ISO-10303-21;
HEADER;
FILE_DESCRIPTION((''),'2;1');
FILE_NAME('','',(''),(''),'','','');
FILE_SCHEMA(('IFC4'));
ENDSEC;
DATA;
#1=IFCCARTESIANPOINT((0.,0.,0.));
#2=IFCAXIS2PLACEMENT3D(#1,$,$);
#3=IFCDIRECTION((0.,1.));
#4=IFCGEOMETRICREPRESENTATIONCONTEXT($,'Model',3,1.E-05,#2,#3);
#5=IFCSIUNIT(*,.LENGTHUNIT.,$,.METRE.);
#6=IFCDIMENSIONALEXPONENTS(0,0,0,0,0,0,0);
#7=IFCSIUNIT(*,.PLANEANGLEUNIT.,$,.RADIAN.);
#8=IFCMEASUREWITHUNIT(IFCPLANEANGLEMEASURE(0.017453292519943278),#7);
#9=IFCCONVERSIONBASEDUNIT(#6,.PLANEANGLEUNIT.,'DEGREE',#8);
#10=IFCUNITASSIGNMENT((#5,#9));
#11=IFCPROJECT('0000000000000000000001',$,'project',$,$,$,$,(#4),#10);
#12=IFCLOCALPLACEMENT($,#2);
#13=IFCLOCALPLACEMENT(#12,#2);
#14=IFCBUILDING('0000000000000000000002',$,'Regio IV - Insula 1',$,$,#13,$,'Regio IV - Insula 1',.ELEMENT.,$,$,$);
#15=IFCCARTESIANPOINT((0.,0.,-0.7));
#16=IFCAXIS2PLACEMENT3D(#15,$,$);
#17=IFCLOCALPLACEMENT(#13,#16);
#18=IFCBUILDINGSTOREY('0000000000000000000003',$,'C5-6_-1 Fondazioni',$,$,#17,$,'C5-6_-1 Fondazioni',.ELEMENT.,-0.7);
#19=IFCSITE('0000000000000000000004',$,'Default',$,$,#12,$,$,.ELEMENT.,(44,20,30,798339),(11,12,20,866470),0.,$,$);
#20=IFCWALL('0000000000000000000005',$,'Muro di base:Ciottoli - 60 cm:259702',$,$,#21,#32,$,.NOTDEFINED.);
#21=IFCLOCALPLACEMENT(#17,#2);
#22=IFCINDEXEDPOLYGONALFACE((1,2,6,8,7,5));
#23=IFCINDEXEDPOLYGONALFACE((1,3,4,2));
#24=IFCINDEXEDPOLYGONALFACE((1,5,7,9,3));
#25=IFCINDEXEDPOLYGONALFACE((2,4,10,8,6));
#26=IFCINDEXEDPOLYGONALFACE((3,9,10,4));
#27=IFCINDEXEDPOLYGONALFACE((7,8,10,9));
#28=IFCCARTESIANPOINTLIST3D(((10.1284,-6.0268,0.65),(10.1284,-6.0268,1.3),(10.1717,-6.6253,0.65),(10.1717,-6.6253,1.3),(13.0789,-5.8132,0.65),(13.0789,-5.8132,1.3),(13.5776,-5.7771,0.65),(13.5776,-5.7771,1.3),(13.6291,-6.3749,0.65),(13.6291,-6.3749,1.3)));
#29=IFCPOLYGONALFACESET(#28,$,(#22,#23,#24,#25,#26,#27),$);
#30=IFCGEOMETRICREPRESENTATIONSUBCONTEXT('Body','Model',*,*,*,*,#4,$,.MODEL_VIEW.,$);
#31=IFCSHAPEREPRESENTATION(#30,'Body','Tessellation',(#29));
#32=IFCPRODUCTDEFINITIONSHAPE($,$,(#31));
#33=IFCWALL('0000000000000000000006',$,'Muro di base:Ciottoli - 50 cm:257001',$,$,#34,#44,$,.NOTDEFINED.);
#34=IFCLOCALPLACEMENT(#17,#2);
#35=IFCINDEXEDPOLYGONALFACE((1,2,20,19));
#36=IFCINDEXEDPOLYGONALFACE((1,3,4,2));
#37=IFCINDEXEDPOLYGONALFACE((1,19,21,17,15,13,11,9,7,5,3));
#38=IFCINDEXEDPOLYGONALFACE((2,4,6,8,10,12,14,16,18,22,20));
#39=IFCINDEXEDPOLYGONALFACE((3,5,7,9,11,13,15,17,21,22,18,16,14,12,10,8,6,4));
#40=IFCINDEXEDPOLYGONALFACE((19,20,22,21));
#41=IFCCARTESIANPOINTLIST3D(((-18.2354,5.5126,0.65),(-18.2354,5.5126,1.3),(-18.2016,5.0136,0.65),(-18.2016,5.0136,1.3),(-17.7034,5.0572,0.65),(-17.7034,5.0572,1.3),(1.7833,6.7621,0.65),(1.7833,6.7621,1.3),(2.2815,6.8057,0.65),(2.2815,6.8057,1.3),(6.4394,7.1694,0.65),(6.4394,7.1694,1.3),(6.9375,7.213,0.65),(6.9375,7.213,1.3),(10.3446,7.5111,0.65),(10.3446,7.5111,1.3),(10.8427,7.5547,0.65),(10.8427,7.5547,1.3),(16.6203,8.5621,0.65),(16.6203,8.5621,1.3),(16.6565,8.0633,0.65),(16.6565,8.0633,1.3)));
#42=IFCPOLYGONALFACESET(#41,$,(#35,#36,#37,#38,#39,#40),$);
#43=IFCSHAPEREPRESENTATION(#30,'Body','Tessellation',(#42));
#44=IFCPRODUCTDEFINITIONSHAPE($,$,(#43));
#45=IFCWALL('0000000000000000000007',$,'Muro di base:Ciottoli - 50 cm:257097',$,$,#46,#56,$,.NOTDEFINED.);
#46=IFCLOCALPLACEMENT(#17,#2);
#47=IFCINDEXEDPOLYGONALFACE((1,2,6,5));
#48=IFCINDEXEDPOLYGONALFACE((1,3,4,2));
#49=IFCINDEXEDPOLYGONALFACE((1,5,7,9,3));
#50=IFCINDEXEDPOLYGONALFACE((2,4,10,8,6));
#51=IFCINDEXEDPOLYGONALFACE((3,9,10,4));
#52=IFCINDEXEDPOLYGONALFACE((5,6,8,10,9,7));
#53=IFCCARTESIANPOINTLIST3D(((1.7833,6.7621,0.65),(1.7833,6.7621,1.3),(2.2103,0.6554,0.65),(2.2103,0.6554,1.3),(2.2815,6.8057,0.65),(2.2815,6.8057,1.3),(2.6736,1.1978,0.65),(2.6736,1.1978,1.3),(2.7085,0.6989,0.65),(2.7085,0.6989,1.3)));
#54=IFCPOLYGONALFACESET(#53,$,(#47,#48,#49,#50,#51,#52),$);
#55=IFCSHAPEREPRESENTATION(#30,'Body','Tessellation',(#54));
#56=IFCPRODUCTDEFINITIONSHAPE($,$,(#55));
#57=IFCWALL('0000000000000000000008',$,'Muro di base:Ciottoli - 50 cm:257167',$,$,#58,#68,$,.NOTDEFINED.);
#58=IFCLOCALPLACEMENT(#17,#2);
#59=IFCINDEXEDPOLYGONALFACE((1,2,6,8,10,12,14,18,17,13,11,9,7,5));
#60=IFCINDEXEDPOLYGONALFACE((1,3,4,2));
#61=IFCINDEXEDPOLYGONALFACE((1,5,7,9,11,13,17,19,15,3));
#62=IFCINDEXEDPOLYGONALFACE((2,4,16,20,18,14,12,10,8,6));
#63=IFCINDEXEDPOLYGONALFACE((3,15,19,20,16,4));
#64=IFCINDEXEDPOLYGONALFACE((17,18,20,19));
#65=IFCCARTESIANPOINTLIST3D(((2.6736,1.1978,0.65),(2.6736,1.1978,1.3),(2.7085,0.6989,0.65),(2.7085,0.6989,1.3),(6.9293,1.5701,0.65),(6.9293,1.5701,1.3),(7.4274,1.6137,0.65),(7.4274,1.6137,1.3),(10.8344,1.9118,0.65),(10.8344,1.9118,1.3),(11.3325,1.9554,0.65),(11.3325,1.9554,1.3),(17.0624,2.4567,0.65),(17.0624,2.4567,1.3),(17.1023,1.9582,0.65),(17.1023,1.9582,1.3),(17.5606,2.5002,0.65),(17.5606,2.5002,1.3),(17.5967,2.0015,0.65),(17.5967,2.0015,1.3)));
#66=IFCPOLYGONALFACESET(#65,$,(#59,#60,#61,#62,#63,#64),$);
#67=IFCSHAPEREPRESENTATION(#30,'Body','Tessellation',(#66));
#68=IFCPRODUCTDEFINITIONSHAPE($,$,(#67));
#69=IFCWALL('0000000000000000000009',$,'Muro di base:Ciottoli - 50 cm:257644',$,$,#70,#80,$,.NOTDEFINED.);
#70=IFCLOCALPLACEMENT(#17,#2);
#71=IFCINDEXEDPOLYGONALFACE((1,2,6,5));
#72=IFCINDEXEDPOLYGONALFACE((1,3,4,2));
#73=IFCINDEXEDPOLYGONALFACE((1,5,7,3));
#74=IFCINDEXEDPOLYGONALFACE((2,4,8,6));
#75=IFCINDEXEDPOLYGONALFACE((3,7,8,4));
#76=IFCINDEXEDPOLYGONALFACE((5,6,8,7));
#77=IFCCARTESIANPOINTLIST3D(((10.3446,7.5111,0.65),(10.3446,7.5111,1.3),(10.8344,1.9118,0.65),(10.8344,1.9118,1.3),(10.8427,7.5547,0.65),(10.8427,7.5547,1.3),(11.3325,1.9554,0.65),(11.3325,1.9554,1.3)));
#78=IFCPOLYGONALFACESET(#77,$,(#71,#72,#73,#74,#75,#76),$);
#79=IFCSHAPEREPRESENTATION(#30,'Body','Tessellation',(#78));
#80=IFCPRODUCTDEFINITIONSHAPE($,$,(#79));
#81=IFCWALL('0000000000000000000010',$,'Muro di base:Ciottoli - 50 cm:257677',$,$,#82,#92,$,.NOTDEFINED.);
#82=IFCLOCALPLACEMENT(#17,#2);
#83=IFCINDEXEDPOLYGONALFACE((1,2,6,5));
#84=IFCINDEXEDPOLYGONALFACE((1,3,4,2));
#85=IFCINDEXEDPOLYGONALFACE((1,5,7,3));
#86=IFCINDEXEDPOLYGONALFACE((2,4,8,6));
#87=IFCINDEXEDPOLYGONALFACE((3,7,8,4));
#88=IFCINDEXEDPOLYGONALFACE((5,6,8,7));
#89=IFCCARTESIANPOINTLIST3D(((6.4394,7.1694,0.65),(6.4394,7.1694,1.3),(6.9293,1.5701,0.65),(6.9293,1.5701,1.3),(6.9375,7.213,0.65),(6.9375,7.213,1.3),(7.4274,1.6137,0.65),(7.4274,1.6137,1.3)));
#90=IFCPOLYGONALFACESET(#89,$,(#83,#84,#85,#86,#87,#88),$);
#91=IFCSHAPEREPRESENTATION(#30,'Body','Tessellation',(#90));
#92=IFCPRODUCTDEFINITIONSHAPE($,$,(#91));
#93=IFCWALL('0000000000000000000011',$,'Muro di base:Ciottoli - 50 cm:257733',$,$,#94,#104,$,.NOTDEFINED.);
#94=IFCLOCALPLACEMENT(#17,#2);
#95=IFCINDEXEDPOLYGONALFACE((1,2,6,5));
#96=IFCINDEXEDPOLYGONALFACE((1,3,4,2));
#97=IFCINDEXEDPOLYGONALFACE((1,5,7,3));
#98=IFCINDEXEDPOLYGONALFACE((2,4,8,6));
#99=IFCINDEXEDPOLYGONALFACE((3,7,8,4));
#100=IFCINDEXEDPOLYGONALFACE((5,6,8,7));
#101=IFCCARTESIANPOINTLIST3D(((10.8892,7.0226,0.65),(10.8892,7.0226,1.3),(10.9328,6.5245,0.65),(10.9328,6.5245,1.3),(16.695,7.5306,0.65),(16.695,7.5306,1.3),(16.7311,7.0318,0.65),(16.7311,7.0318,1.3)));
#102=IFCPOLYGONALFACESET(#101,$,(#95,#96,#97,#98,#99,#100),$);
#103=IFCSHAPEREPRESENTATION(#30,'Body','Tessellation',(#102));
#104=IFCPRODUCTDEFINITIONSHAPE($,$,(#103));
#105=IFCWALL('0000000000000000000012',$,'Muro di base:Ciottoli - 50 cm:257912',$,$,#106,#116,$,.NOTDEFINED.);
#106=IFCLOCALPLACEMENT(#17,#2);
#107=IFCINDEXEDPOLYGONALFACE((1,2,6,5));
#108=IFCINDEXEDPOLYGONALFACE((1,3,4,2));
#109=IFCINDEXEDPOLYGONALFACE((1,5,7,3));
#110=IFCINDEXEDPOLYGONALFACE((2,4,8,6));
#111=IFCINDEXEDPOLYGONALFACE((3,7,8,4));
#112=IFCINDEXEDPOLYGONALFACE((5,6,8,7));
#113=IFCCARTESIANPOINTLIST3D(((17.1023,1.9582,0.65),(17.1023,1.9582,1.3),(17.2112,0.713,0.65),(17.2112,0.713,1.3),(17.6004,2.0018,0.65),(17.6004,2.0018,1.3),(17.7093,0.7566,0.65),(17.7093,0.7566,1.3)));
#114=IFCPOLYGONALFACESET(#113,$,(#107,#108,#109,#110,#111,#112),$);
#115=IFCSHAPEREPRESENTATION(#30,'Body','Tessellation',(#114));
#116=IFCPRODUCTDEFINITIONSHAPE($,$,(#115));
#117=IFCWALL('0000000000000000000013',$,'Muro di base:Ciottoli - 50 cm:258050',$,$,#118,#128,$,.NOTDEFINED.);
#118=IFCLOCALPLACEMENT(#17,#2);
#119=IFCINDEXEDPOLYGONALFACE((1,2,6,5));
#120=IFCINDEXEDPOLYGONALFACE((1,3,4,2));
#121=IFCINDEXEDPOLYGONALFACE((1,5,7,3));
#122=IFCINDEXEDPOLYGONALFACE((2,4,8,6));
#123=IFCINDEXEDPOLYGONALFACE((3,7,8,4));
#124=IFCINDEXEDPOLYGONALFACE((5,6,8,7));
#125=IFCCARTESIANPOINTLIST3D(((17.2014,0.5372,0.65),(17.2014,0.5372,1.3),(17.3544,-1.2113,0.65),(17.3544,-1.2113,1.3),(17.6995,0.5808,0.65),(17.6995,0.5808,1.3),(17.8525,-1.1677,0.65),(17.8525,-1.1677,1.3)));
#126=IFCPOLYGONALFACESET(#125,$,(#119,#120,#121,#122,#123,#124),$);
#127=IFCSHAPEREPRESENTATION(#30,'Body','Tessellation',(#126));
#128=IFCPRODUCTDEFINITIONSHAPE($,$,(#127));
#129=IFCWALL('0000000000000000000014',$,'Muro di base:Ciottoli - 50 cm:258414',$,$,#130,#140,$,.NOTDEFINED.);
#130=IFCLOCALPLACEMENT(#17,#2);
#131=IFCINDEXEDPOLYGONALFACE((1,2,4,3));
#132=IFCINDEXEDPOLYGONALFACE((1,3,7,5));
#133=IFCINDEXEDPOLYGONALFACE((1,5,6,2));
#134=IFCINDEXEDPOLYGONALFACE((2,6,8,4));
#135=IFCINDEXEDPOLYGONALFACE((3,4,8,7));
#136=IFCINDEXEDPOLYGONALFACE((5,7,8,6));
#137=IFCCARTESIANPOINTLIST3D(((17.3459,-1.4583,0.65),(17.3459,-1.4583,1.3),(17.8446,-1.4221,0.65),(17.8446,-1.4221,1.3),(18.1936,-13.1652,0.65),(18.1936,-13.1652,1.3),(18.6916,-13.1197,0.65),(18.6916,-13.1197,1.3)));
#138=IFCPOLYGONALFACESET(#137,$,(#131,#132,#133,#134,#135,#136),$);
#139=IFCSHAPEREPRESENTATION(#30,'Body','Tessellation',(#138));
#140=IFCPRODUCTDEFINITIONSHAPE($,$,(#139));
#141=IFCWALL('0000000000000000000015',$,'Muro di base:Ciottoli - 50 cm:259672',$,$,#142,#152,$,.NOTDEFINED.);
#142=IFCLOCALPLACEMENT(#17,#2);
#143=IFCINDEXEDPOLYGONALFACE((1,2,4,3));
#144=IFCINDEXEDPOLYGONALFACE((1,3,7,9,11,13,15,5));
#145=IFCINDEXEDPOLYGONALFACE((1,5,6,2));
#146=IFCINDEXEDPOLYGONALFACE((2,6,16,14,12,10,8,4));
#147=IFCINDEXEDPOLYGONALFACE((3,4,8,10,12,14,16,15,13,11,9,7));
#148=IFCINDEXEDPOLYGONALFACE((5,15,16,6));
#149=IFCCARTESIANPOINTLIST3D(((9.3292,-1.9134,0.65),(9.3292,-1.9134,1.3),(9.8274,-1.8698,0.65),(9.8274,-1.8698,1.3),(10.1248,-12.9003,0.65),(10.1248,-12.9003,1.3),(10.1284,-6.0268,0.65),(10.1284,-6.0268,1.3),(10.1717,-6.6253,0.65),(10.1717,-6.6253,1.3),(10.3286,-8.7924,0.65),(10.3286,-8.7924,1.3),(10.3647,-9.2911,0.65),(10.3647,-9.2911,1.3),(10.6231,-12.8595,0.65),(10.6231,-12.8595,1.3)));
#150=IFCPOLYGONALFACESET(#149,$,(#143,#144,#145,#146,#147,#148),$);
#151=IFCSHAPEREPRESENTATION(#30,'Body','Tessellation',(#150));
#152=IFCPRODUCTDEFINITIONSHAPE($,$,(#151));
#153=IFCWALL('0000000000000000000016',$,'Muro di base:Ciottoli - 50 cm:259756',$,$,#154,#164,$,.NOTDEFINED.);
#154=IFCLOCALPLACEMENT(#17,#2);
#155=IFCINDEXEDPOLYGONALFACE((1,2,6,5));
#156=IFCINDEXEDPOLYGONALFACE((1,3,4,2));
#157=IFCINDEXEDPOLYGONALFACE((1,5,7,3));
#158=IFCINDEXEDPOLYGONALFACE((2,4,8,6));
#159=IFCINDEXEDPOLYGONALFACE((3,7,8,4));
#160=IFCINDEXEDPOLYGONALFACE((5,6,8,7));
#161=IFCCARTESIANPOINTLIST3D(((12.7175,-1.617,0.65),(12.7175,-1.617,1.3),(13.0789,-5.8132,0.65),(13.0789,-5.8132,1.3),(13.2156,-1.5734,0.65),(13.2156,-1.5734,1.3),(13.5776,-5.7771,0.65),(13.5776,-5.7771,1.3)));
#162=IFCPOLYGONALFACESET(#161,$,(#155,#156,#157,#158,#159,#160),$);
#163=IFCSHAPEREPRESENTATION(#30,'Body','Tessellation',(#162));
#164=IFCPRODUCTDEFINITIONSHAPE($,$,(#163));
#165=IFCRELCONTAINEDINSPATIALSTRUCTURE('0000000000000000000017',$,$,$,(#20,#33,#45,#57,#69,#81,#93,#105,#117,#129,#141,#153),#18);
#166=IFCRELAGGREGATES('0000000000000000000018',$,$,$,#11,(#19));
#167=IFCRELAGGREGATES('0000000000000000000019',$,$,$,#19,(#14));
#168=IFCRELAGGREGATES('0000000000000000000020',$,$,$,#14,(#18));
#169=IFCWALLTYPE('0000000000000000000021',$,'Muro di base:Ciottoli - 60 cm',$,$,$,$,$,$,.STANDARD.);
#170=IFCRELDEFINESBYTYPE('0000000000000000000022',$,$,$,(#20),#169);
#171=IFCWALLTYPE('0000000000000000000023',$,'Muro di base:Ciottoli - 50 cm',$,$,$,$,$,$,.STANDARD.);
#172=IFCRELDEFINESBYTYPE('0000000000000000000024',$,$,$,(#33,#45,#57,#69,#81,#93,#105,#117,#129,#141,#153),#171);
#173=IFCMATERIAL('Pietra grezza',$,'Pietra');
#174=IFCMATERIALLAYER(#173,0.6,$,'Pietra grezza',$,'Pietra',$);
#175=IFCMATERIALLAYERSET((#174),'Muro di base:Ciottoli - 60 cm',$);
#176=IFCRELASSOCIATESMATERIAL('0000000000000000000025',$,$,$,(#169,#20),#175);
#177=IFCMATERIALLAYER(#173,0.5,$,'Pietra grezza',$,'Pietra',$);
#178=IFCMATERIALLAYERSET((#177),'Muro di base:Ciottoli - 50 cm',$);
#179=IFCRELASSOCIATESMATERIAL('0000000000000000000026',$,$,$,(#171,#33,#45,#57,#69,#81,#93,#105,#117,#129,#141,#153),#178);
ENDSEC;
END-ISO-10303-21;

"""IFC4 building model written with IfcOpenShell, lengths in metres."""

from ifc_helpers import new_model, entity, si_unit, converted_unit, direction, frame, frame_2d, origin, place, context, subcontext, project, spatial, polyline, rectangle, outline, extrude, material, layer, layer_set, layer_usage, type_object, element, save


model = new_model("IFC4")

# Units and contexts
model_context = context("Model", 3, precision=1e-05, world=origin(), true_north=direction((0.0, 1.0)))
body_context = subcontext(model_context, "Body", "Model", "MODEL_VIEW")
ifc_project = project(units=[si_unit("LENGTHUNIT", "METRE"), converted_unit("PLANEANGLEUNIT", "DEGREE", entity("IfcPlaneAngleMeasure", 0.017453292519943278), si_unit("PLANEANGLEUNIT", "RADIAN"), dimensions=[0, 0, 0, 0, 0, 0, 0])], contexts=[model_context])

# Site, building, storey
site_placement = place(None, origin())
site = spatial("IfcSite", under=ifc_project, at=site_placement, Name="Default", CompositionType="ELEMENT", RefLatitude=(44, 20, 30, 798339), RefLongitude=(11, 12, 20, 866470), RefElevation=0.0)
building_placement = place(site_placement, origin())
building = spatial("IfcBuilding", under=site, at=building_placement, Name="Regio IV - Insula 1", LongName="Regio IV - Insula 1", CompositionType="ELEMENT")
storey_placement = place(building_placement, frame((0.0, 0.0, -0.7)))
storey = spatial("IfcBuildingStorey", under=building, at=storey_placement, Name="C5-6_-1 Fondazioni", LongName="C5-6_-1 Fondazioni", CompositionType="ELEMENT", Elevation=-0.7)

# Walls
ifc_material = material(Name="Pietra grezza", Category="Pietra")
ifc_layer_1 = layer(ifc_material, 0.6, Name="Pietra grezza", Category="Pietra")
ifc_layer_set_1 = layer_set([ifc_layer_1], Name="Muro di base:Ciottoli - 60 cm")
ifc_layer_usage_1 = layer_usage(ifc_layer_set_1, "AXIS2", "NEGATIVE", 0.3)
wall_type_1 = type_object("IfcWallType", Name="Muro di base:Ciottoli - 60 cm", PredefinedType="STANDARD", material=ifc_layer_set_1)
wall_1_placement = place(storey_placement, frame((10.15, -6.3261, 0.65), z_axis=(0.0, 0.0, 1.0), x_axis=(0.997389, 0.07222, 0.0)))
element("IfcWall", 1, at=wall_1_placement, inside=storey, type_object=wall_type_1, material=ifc_layer_usage_1, Name="Muro di base:Ciottoli - 60 cm:259702", PredefinedType="NOTDEFINED", context=body_context, shape_type="SweptSolid", body=[
    extrude(outline(polyline([(3.4665, -0.3), (3.4583, 0.3), (2.9582, 0.3), (0.0, 0.3), (0.0, -0.3), (3.4665, -0.3)])), origin(), (0.0, 0.0, 1.0), 0.65),
])
ifc_layer_2 = layer(ifc_material, 0.5, Name="Pietra grezza", Category="Pietra")
ifc_layer_set_2 = layer_set([ifc_layer_2], Name="Muro di base:Ciottoli - 50 cm")
ifc_layer_usage_2 = layer_usage(ifc_layer_set_2, "AXIS2", "NEGATIVE", 0.25)
wall_type_2 = type_object("IfcWallType", Name="Muro di base:Ciottoli - 50 cm", PredefinedType="STANDARD", material=ifc_layer_set_2)
wall_2_placement = place(storey_placement, frame((16.6421, 8.313, 0.65), z_axis=(0.0, 0.0, 1.0), x_axis=(-0.996195, -0.087156, 0.0)))
element("IfcWall", 2, at=wall_2_placement, inside=storey, type_object=wall_type_2, material=ifc_layer_usage_2, Name="Muro di base:Ciottoli - 50 cm:257001", PredefinedType="NOTDEFINED", context=body_context, shape_type="SweptSolid", body=[
    extrude(outline(polyline([(34.9889, -0.25), (34.9987, 0.25), (34.4986, 0.25), (14.9375, 0.25), (14.4374, 0.25), (10.2635, 0.25), (9.7635, 0.25), (6.3435, 0.25), (5.8435, 0.25), (0.0075, 0.25), (0.0, -0.25), (34.9889, -0.25)])), origin(), (0.0, 0.0, 1.0), 0.65),
])
ifc_layer_usage_3 = layer_usage(ifc_layer_set_2, "AXIS2", "NEGATIVE", 0.25)
wall_3_placement = place(storey_placement, frame((2.0321, 6.7882, 0.65), z_axis=(0.0, 0.0, 1.0), x_axis=(0.069756, -0.997564, 0.0)))
element("IfcWall", 3, at=wall_3_placement, inside=storey, type_object=wall_type_2, material=ifc_layer_usage_3, Name="Muro di base:Ciottoli - 50 cm:257097", PredefinedType="NOTDEFINED", context=body_context, shape_type="SweptSolid", body=[
    extrude(outline(polyline([(6.1303, -0.25), (6.1216, 0.25), (5.6215, 0.25), (0.0, 0.25), (0.0087, -0.25), (6.1303, -0.25)])), origin(), (0.0, 0.0, 1.0), 0.65),
])
ifc_layer_usage_4 = layer_usage(ifc_layer_set_2, "AXIS2", "NEGATIVE", 0.25)
wall_4_placement = place(storey_placement, frame((2.6867, 0.948, 0.65), z_axis=(0.0, 0.0, 1.0), x_axis=(0.996195, 0.087156, 0.0)))
element("IfcWall", 4, at=wall_4_placement, inside=storey, type_object=wall_type_2, material=ifc_layer_usage_4, Name="Muro di base:Ciottoli - 50 cm:257167", PredefinedType="NOTDEFINED", context=body_context, shape_type="SweptSolid", body=[
    extrude(outline(polyline([(14.9451, -0.25), (14.9526, 0.25), (14.4525, 0.25), (8.7007, 0.25), (8.2007, 0.25), (4.7807, 0.25), (4.2807, 0.25), (0.0087, 0.25), (0.0, -0.25), (14.4488, -0.25), (14.9451, -0.25)])), origin(), (0.0, 0.0, 1.0), 0.65),
])
ifc_layer_usage_5 = layer_usage(ifc_layer_set_2, "AXIS2", "NEGATIVE", 0.25)
wall_5_placement = place(storey_placement, frame((10.5936, 7.5329, 0.65), z_axis=(0.0, 0.0, 1.0), x_axis=(0.087156, -0.996195, 0.0)))
element("IfcWall", 5, at=wall_5_placement, inside=storey, type_object=wall_type_2, material=ifc_layer_usage_5, Name="Muro di base:Ciottoli - 50 cm:257644", PredefinedType="NOTDEFINED", context=body_context, shape_type="SweptSolid", body=[
    extrude(rectangle(XDim=5.6207, YDim=0.5, at=frame_2d((2.8103, 0.0), x_axis=(-1.0, 0.0))), origin(), (0.0, 0.0, 1.0), 0.65),
])
ifc_layer_usage_6 = layer_usage(ifc_layer_set_2, "AXIS2", "NEGATIVE", 0.25)
wall_6_placement = place(storey_placement, frame((6.6885, 7.1912, 0.65), z_axis=(0.0, 0.0, 1.0), x_axis=(0.087156, -0.996195, 0.0)))
element("IfcWall", 6, at=wall_6_placement, inside=storey, type_object=wall_type_2, material=ifc_layer_usage_6, Name="Muro di base:Ciottoli - 50 cm:257677", PredefinedType="NOTDEFINED", context=body_context, shape_type="SweptSolid", body=[
    extrude(rectangle(XDim=5.6207, YDim=0.5, at=frame_2d((2.8103, 0.0), x_axis=(-1.0, 0.0))), origin(), (0.0, 0.0, 1.0), 0.65),
])
ifc_layer_usage_7 = layer_usage(ifc_layer_set_2, "AXIS2", "NEGATIVE", 0.25)
wall_7_placement = place(storey_placement, frame((10.911, 6.7736, 0.65), z_axis=(0.0, 0.0, 1.0), x_axis=(0.996195, 0.087156, 0.0)))
element("IfcWall", 7, at=wall_7_placement, inside=storey, type_object=wall_type_2, material=ifc_layer_usage_7, Name="Muro di base:Ciottoli - 50 cm:257733", PredefinedType="NOTDEFINED", context=body_context, shape_type="SweptSolid", body=[
    extrude(outline(polyline([(5.8205, -0.25), (5.828, 0.25), (0.0, 0.25), (0.0, -0.25), (5.8205, -0.25)])), origin(), (0.0, 0.0, 1.0), 0.65),
])
ifc_layer_usage_8 = layer_usage(ifc_layer_set_2, "AXIS2", "NEGATIVE", 0.25)
wall_8_placement = place(storey_placement, frame((17.3514, 1.98, 0.65), z_axis=(0.0, 0.0, 1.0), x_axis=(0.087156, -0.996195, 0.0)))
element("IfcWall", 8, at=wall_8_placement, inside=storey, type_object=wall_type_2, material=ifc_layer_usage_8, Name="Muro di base:Ciottoli - 50 cm:257912", PredefinedType="NOTDEFINED", context=body_context, shape_type="SweptSolid", body=[
    extrude(rectangle(XDim=1.25, YDim=0.5, at=frame_2d((0.625, 0.0), x_axis=(-1.0, 0.0))), origin(), (0.0, 0.0, 1.0), 0.65),
])
ifc_layer_usage_9 = layer_usage(ifc_layer_set_2, "AXIS2", "NEGATIVE", 0.25)
wall_9_placement = place(storey_placement, frame((17.4505, 0.559, 0.65), z_axis=(0.0, 0.0, 1.0), x_axis=(0.087156, -0.996195, 0.0)))
element("IfcWall", 9, at=wall_9_placement, inside=storey, type_object=wall_type_2, material=ifc_layer_usage_9, Name="Muro di base:Ciottoli - 50 cm:258050", PredefinedType="NOTDEFINED", context=body_context, shape_type="SweptSolid", body=[
    extrude(rectangle(XDim=1.7552, YDim=0.5, at=frame_2d((0.8776, 0.0), x_axis=(-1.0, 0.0))), origin(), (0.0, 0.0, 1.0), 0.65),
])
ifc_layer_usage_10 = layer_usage(ifc_layer_set_2, "AXIS2", "NEGATIVE", 0.25)
wall_10_placement = place(storey_placement, frame((17.5953, -1.4402, 0.65), z_axis=(0.0, 0.0, 1.0), x_axis=(0.07222, -0.997389, 0.0)))
element("IfcWall", 10, at=wall_10_placement, inside=storey, type_object=wall_type_2, material=ifc_layer_usage_10, Name="Muro di base:Ciottoli - 50 cm:258414", PredefinedType="NOTDEFINED", context=body_context, shape_type="SweptSolid", body=[
    extrude(outline(polyline([(11.7376, -0.25), (11.7282, 0.25), (0.0, 0.25), (0.0, -0.25), (11.7376, -0.25)])), origin(), (0.0, 0.0, 1.0), 0.65),
])
ifc_layer_usage_11 = layer_usage(ifc_layer_set_2, "AXIS2", "NEGATIVE", 0.25)
wall_11_placement = place(storey_placement, frame((9.578, -1.8879, 0.65), z_axis=(0.0, 0.0, 1.0), x_axis=(0.07222, -0.997389, 0.0)))
element("IfcWall", 11, at=wall_11_placement, inside=storey, type_object=wall_type_2, material=ifc_layer_usage_11, Name="Muro di base:Ciottoli - 50 cm:259672", PredefinedType="NOTDEFINED", context=body_context, shape_type="SweptSolid", body=[
    extrude(outline(polyline([(11.0232, -0.25), (11.0185, 0.25), (7.4408, 0.25), (6.9407, 0.25), (4.7679, 0.25), (4.1679, 0.25), (0.0, 0.25), (0.0075, -0.25), (11.0232, -0.25)])), origin(), (0.0, 0.0, 1.0), 0.65),
])
ifc_layer_usage_12 = layer_usage(ifc_layer_set_2, "AXIS2", "NEGATIVE", 0.25)
wall_12_placement = place(storey_placement, frame((13.3286, -5.7985, 0.65), z_axis=(0.0, 0.0, 1.0), x_axis=(-0.085801, 0.996312, 0.0)))
element("IfcWall", 12, at=wall_12_placement, inside=storey, type_object=wall_type_2, material=ifc_layer_usage_12, Name="Muro di base:Ciottoli - 50 cm:259756", PredefinedType="NOTDEFINED", context=body_context, shape_type="SweptSolid", body=[
    extrude(outline(polyline([(4.2193, -0.25), (4.2186, 0.25), (0.0068, 0.25), (0.0, -0.25), (4.2193, -0.25)])), origin(), (0.0, 0.0, 1.0), 0.65),
])

save(model, "model.ifc")
